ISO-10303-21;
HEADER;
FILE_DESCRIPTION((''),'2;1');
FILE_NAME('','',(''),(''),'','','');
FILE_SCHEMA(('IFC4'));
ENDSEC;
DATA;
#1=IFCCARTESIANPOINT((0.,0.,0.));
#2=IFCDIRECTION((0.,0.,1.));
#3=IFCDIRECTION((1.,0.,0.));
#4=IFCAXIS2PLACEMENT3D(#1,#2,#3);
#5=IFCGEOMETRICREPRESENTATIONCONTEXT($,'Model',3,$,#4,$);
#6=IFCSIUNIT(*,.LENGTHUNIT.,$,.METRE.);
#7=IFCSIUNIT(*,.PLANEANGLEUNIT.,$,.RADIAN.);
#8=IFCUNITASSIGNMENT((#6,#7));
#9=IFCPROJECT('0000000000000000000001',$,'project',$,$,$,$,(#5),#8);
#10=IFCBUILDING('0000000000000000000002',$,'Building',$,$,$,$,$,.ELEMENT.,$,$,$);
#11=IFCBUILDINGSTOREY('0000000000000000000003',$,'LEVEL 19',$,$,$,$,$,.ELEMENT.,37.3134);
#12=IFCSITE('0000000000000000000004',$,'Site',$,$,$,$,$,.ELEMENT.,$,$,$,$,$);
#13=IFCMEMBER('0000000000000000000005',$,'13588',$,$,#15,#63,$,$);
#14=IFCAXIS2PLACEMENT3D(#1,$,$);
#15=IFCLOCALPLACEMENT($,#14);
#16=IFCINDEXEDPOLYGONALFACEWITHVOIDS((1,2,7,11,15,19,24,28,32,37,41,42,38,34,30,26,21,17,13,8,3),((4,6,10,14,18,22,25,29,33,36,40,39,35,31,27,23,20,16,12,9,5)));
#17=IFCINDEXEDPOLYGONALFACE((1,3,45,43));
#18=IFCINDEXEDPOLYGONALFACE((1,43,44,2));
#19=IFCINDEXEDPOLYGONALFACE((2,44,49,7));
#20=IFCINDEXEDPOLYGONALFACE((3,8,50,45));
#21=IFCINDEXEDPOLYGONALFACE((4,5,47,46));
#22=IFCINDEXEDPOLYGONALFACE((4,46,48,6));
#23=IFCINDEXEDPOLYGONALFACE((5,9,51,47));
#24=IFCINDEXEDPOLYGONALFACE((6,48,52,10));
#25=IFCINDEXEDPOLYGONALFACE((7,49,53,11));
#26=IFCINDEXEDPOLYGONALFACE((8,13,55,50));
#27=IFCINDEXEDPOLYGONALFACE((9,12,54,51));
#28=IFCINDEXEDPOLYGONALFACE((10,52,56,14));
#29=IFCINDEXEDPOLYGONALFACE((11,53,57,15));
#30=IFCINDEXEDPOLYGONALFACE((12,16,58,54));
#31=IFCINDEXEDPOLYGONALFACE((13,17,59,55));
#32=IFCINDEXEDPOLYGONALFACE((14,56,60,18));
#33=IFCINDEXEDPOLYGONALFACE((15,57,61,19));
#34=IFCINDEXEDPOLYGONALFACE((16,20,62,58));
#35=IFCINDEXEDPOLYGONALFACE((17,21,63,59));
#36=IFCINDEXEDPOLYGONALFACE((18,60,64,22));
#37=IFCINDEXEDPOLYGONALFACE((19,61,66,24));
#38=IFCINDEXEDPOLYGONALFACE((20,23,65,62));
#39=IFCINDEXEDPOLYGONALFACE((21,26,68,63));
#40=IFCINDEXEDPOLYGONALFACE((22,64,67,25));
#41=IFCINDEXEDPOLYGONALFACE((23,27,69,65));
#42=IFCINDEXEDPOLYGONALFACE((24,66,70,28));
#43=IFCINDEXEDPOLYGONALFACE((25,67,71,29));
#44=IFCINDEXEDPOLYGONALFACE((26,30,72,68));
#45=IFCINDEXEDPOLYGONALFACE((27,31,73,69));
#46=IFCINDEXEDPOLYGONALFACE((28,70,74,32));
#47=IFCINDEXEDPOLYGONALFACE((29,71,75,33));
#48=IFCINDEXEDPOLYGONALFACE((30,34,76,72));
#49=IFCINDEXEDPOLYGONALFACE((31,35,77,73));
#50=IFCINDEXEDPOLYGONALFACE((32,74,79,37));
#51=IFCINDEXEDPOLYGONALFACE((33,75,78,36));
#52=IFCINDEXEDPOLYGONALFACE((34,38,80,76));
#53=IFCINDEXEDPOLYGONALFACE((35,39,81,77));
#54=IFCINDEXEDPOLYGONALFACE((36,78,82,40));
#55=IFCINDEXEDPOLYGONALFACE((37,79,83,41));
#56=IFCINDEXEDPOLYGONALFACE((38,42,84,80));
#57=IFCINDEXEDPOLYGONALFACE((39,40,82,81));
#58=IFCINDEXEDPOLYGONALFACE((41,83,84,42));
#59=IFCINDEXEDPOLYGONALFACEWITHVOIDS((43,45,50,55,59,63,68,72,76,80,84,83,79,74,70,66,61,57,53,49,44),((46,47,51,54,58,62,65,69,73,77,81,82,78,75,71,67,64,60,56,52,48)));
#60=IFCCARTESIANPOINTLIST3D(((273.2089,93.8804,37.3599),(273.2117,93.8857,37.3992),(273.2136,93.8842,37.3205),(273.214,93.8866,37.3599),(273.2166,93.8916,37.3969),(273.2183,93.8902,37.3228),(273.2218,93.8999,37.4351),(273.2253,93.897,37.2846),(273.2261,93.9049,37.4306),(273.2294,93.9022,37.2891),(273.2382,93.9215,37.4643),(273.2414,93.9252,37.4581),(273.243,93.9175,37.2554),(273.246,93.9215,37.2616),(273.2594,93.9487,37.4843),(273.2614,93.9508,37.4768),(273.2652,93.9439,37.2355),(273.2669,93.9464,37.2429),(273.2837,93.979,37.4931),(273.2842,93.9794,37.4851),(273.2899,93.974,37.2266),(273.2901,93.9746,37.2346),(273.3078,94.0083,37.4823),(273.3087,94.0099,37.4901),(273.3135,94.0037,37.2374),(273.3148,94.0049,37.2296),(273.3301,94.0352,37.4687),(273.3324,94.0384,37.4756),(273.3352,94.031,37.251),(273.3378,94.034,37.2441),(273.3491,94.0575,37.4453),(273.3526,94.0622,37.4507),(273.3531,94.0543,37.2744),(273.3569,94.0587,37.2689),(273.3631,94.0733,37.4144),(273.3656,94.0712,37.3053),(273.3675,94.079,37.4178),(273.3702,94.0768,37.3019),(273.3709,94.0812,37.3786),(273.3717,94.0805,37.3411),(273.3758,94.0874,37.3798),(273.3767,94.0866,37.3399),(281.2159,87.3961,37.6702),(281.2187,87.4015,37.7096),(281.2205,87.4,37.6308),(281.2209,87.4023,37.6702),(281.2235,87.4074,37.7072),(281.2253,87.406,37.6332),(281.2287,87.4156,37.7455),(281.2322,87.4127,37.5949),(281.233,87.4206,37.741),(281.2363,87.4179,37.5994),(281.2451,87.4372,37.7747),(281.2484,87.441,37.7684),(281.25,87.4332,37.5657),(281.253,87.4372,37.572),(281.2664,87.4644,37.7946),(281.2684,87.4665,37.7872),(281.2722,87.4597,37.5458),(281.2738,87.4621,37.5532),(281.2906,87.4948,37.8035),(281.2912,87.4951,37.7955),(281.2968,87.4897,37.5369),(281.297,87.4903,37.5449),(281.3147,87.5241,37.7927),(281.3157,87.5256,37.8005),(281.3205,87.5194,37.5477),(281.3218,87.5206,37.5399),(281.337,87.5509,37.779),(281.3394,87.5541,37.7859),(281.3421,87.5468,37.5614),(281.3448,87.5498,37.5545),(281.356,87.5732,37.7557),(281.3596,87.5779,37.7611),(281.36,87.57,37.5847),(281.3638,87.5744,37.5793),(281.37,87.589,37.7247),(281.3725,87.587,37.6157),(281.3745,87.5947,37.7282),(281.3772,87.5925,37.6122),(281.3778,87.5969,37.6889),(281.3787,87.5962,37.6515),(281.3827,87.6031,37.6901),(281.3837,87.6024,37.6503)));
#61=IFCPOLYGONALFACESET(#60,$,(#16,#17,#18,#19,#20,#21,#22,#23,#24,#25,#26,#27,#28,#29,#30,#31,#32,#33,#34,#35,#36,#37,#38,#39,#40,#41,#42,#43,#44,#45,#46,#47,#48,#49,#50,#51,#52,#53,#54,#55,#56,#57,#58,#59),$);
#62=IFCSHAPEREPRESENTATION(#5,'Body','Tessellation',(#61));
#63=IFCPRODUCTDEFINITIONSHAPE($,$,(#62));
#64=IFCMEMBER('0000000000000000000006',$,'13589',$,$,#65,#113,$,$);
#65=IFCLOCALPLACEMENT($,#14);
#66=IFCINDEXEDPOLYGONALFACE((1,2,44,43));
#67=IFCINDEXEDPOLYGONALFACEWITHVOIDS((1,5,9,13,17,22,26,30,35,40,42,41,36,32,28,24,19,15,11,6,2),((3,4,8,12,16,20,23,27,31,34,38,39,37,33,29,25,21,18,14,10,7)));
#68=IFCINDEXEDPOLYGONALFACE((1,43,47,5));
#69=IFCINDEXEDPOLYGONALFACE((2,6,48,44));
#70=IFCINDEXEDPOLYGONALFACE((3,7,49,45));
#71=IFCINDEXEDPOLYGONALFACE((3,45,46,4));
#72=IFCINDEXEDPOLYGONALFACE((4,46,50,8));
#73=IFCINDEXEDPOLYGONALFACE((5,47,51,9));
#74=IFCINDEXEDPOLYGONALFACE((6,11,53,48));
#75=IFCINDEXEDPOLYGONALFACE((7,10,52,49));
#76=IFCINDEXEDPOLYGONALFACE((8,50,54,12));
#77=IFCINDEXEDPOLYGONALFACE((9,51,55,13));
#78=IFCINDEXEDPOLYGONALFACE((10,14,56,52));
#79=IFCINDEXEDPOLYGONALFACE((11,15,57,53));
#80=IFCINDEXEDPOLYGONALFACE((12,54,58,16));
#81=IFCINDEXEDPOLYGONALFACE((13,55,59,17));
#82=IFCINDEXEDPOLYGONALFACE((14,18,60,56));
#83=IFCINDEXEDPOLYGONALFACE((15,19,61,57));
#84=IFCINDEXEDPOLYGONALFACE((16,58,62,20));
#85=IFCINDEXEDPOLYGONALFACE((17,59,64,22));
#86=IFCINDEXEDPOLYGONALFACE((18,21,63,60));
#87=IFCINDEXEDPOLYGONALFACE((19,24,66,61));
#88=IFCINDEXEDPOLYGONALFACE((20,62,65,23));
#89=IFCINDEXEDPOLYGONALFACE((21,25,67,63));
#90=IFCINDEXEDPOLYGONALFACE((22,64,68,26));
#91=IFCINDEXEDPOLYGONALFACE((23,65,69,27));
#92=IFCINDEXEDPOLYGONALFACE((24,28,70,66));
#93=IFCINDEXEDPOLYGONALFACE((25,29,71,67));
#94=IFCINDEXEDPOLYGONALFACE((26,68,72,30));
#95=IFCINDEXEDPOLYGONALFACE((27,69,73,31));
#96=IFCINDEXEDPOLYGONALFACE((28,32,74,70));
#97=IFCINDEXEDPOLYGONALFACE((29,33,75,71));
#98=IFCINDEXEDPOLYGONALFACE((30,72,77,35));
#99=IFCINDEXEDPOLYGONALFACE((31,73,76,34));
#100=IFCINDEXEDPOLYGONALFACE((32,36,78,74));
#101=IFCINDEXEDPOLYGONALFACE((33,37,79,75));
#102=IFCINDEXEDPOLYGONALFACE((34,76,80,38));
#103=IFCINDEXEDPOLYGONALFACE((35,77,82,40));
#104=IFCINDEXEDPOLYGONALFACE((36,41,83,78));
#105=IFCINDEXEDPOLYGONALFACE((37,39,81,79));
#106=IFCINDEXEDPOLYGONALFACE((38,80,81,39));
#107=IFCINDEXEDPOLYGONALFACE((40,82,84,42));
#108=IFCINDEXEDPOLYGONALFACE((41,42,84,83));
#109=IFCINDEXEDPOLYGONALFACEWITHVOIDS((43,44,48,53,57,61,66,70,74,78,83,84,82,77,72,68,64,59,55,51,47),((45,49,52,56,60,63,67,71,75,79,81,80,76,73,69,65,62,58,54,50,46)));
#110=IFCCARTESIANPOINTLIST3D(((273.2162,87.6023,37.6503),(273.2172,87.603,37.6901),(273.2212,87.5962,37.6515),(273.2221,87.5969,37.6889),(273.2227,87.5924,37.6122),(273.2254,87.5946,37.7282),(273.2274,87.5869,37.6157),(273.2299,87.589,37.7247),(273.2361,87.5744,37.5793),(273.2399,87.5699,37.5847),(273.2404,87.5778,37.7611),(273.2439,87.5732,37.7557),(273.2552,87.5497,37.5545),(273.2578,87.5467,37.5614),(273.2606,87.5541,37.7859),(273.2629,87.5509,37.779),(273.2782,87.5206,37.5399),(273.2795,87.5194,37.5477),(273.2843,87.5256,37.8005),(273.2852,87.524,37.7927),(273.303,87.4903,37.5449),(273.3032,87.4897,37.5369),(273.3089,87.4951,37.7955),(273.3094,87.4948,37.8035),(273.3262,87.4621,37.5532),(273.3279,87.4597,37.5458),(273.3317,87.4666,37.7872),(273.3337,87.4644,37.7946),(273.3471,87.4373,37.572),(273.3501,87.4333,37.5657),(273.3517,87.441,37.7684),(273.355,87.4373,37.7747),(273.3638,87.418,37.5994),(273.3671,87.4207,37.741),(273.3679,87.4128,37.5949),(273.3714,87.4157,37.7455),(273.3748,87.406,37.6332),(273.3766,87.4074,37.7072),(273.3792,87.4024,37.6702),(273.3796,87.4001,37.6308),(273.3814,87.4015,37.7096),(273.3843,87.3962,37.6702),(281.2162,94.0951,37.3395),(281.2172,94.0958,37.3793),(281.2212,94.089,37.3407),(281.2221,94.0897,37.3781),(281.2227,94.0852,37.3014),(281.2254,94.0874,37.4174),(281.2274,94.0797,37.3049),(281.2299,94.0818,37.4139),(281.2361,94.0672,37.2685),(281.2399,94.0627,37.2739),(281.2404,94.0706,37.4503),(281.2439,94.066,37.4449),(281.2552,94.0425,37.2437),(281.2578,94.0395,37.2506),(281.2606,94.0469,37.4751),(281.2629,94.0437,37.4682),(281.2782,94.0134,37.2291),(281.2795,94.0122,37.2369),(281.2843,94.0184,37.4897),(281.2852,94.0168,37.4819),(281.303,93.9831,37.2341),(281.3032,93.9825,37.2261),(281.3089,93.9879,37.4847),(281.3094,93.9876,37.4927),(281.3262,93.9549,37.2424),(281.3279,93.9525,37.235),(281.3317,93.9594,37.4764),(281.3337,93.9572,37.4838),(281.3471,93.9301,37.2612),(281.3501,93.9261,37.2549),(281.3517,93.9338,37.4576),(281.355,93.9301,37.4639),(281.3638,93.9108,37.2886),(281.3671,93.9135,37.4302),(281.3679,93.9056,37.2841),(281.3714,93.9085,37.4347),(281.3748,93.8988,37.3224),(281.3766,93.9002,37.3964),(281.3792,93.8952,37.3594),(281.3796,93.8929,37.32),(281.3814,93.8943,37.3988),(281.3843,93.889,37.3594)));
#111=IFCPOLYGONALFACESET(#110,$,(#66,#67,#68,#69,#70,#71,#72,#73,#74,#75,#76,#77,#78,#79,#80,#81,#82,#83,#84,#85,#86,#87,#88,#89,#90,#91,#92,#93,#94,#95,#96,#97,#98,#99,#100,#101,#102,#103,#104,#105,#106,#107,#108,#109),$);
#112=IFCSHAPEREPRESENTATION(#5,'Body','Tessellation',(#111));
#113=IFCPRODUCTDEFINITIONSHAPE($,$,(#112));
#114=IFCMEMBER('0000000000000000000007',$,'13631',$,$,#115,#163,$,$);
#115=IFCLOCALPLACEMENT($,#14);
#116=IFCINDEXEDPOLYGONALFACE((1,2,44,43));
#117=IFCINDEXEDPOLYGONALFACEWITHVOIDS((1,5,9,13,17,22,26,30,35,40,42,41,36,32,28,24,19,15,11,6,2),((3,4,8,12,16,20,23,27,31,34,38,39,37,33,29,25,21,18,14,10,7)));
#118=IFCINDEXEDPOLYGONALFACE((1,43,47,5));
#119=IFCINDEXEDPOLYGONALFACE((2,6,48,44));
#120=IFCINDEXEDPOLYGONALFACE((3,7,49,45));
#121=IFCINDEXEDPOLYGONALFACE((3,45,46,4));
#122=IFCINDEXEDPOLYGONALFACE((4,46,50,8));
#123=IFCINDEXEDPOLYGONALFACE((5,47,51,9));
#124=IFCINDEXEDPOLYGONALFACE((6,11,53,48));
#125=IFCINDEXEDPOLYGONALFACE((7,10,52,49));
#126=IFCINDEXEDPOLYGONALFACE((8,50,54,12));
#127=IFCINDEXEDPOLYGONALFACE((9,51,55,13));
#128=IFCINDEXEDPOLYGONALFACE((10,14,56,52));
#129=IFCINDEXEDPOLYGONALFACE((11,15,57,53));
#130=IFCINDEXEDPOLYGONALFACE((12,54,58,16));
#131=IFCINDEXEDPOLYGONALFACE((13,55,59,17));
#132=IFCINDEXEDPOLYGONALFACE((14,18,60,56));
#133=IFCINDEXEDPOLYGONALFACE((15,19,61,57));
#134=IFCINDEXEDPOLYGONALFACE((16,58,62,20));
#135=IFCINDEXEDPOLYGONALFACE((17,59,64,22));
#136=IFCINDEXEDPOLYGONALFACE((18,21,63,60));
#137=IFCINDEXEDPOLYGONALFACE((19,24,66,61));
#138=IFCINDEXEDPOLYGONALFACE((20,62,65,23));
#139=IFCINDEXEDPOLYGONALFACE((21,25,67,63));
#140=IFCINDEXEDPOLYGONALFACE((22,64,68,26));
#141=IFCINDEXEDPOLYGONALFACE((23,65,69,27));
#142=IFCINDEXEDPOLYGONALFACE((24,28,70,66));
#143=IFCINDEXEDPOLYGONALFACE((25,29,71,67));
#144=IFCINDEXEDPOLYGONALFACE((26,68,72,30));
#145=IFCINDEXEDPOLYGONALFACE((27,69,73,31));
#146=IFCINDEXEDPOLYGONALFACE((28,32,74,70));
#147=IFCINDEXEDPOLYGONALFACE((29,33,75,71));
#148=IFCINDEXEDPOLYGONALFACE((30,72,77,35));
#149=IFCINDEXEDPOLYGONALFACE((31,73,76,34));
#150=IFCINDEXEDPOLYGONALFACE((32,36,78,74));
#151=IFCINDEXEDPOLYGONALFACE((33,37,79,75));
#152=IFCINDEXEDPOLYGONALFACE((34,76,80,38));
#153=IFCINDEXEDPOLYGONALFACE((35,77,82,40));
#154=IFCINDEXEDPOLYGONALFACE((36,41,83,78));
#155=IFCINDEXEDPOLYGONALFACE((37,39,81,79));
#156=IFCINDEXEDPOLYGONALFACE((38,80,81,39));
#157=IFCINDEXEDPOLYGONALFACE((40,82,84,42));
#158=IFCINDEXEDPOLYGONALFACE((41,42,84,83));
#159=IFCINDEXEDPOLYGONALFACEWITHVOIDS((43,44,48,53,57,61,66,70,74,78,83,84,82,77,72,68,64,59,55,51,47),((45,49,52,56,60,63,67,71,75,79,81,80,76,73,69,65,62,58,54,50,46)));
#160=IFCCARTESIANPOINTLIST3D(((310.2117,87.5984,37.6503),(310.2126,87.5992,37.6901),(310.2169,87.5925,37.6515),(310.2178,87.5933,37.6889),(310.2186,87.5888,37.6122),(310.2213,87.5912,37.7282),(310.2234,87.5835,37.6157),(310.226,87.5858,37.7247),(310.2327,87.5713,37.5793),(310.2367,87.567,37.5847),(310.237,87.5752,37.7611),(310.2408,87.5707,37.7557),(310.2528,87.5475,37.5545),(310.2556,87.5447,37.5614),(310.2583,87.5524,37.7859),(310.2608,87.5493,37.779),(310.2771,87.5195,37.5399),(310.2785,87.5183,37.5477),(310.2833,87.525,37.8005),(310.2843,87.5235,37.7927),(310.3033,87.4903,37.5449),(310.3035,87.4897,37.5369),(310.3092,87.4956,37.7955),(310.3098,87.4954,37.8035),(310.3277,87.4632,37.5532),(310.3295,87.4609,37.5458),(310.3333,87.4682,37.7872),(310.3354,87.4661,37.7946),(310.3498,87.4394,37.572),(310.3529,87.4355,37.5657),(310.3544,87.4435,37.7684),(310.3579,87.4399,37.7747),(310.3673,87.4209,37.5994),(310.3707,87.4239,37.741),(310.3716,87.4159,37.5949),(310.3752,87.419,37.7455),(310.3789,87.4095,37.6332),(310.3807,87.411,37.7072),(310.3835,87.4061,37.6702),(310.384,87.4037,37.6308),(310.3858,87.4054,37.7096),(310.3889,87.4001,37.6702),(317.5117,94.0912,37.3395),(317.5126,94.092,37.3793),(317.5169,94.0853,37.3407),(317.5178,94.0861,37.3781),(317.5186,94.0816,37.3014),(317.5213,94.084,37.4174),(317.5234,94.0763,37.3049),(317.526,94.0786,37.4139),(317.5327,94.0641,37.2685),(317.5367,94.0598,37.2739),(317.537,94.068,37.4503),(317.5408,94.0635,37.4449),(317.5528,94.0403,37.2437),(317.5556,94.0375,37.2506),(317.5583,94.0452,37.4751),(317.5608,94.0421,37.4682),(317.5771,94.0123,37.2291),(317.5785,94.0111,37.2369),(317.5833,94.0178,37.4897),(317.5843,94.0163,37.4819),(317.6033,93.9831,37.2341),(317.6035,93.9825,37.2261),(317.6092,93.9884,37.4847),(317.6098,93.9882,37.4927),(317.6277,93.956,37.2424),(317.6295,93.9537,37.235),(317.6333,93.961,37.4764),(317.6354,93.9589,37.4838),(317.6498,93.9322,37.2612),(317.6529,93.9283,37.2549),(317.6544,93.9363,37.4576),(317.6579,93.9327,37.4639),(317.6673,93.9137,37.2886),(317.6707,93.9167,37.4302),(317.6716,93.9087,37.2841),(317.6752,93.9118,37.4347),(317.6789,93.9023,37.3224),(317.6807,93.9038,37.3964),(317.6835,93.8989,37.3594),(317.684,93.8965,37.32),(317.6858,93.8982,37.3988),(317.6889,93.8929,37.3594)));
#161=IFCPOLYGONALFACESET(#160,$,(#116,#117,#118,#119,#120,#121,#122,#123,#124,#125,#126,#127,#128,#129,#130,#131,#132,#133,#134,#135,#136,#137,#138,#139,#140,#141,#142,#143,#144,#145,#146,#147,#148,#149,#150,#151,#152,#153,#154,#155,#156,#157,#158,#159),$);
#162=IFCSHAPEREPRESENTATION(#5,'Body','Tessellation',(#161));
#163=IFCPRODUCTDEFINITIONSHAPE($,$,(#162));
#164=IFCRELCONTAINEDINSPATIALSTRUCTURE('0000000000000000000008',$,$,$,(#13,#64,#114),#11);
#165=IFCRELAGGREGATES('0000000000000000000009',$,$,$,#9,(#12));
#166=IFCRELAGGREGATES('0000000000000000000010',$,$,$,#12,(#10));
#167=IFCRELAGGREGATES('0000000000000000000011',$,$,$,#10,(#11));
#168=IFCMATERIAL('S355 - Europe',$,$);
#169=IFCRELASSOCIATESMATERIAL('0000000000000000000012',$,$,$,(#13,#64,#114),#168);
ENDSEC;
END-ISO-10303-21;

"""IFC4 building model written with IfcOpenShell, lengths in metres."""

from ifc_helpers import new_model, si_unit, frame, origin_with_axes, origin_2d_with_axis, place, context, project, spatial, hollow_circle, extrude, material, material_profile, profile_set, profile_usage, element, save


model = new_model("IFC4")

# Units and contexts
model_context = context("Model", 3, world=origin_with_axes())
ifc_project = project(units=[si_unit("LENGTHUNIT", "METRE"), si_unit("PLANEANGLEUNIT", "RADIAN")], contexts=[model_context])

# Site, building, storey
site = spatial("IfcSite", under=ifc_project, Name="Site", CompositionType="ELEMENT")
building = spatial("IfcBuilding", under=site, Name="Building", CompositionType="ELEMENT")
storey = spatial("IfcBuildingStorey", under=building, Name="LEVEL 19", CompositionType="ELEMENT", Elevation=37.3134)

# Shared definitions
ifc_material = material(Name="S355 - Europe")

# Members
ifc_material_profile_1 = material_profile(ifc_material, hollow_circle(Radius=0.1337, WallThickness=0.008, at=origin_2d_with_axis()))
ifc_profile_set_1 = profile_set([ifc_material_profile_1])
ifc_profile_usage_1 = profile_usage(ifc_profile_set_1, cardinal=10)
member_1_placement = place(None, frame((281.3, 87.5, 37.6702), z_axis=(-0.776775, 0.629058, -0.030108), x_axis=(-0.630593, -0.776114, 0.0)))
element("IfcMember", 1, at=member_1_placement, inside=storey, material=ifc_profile_usage_1, Name="13588", context=model_context, shape_type="SweptSolid", body=[
    extrude(hollow_circle(Radius=0.1337, WallThickness=0.008, at=origin_2d_with_axis()), origin_with_axes(), (0.0, 0.0, 1.0), 10.3079),
])
ifc_material_profile_2 = material_profile(ifc_material, hollow_circle(Radius=0.1337, WallThickness=0.008, at=origin_2d_with_axis()))
ifc_profile_set_2 = profile_set([ifc_material_profile_2])
ifc_profile_usage_2 = profile_usage(ifc_profile_set_2, cardinal=10)
member_2_placement = place(None, frame((281.3, 93.9928, 37.3594), z_axis=(-0.776103, -0.629885, 0.030152), x_axis=(0.630071, -0.776537, 0.0)))
element("IfcMember", 2, at=member_2_placement, inside=storey, material=ifc_profile_usage_2, Name="13589", context=model_context, shape_type="SweptSolid", body=[
    extrude(hollow_circle(Radius=0.1337, WallThickness=0.008, at=origin_2d_with_axis()), origin_with_axes(), (0.0, 0.0, 1.0), 10.3079),
])
ifc_material_profile_3 = material_profile(ifc_material, hollow_circle(Radius=0.1337, WallThickness=0.008, at=origin_2d_with_axis()))
ifc_profile_set_3 = profile_set([ifc_material_profile_3])
ifc_profile_usage_3 = profile_usage(ifc_profile_set_3, cardinal=10)
member_3_placement = place(None, frame((317.6, 93.9928, 37.3594), z_axis=(-0.746833, -0.664251, 0.031797), x_axis=(0.664587, -0.74721, 0.0)))
element("IfcMember", 3, at=member_3_placement, inside=storey, material=ifc_profile_usage_3, Name="13631", context=model_context, shape_type="SweptSolid", body=[
    extrude(hollow_circle(Radius=0.1337, WallThickness=0.008, at=origin_2d_with_axis()), origin_with_axes(), (0.0, 0.0, 1.0), 9.7746),
])

save(model, "model.ifc")
